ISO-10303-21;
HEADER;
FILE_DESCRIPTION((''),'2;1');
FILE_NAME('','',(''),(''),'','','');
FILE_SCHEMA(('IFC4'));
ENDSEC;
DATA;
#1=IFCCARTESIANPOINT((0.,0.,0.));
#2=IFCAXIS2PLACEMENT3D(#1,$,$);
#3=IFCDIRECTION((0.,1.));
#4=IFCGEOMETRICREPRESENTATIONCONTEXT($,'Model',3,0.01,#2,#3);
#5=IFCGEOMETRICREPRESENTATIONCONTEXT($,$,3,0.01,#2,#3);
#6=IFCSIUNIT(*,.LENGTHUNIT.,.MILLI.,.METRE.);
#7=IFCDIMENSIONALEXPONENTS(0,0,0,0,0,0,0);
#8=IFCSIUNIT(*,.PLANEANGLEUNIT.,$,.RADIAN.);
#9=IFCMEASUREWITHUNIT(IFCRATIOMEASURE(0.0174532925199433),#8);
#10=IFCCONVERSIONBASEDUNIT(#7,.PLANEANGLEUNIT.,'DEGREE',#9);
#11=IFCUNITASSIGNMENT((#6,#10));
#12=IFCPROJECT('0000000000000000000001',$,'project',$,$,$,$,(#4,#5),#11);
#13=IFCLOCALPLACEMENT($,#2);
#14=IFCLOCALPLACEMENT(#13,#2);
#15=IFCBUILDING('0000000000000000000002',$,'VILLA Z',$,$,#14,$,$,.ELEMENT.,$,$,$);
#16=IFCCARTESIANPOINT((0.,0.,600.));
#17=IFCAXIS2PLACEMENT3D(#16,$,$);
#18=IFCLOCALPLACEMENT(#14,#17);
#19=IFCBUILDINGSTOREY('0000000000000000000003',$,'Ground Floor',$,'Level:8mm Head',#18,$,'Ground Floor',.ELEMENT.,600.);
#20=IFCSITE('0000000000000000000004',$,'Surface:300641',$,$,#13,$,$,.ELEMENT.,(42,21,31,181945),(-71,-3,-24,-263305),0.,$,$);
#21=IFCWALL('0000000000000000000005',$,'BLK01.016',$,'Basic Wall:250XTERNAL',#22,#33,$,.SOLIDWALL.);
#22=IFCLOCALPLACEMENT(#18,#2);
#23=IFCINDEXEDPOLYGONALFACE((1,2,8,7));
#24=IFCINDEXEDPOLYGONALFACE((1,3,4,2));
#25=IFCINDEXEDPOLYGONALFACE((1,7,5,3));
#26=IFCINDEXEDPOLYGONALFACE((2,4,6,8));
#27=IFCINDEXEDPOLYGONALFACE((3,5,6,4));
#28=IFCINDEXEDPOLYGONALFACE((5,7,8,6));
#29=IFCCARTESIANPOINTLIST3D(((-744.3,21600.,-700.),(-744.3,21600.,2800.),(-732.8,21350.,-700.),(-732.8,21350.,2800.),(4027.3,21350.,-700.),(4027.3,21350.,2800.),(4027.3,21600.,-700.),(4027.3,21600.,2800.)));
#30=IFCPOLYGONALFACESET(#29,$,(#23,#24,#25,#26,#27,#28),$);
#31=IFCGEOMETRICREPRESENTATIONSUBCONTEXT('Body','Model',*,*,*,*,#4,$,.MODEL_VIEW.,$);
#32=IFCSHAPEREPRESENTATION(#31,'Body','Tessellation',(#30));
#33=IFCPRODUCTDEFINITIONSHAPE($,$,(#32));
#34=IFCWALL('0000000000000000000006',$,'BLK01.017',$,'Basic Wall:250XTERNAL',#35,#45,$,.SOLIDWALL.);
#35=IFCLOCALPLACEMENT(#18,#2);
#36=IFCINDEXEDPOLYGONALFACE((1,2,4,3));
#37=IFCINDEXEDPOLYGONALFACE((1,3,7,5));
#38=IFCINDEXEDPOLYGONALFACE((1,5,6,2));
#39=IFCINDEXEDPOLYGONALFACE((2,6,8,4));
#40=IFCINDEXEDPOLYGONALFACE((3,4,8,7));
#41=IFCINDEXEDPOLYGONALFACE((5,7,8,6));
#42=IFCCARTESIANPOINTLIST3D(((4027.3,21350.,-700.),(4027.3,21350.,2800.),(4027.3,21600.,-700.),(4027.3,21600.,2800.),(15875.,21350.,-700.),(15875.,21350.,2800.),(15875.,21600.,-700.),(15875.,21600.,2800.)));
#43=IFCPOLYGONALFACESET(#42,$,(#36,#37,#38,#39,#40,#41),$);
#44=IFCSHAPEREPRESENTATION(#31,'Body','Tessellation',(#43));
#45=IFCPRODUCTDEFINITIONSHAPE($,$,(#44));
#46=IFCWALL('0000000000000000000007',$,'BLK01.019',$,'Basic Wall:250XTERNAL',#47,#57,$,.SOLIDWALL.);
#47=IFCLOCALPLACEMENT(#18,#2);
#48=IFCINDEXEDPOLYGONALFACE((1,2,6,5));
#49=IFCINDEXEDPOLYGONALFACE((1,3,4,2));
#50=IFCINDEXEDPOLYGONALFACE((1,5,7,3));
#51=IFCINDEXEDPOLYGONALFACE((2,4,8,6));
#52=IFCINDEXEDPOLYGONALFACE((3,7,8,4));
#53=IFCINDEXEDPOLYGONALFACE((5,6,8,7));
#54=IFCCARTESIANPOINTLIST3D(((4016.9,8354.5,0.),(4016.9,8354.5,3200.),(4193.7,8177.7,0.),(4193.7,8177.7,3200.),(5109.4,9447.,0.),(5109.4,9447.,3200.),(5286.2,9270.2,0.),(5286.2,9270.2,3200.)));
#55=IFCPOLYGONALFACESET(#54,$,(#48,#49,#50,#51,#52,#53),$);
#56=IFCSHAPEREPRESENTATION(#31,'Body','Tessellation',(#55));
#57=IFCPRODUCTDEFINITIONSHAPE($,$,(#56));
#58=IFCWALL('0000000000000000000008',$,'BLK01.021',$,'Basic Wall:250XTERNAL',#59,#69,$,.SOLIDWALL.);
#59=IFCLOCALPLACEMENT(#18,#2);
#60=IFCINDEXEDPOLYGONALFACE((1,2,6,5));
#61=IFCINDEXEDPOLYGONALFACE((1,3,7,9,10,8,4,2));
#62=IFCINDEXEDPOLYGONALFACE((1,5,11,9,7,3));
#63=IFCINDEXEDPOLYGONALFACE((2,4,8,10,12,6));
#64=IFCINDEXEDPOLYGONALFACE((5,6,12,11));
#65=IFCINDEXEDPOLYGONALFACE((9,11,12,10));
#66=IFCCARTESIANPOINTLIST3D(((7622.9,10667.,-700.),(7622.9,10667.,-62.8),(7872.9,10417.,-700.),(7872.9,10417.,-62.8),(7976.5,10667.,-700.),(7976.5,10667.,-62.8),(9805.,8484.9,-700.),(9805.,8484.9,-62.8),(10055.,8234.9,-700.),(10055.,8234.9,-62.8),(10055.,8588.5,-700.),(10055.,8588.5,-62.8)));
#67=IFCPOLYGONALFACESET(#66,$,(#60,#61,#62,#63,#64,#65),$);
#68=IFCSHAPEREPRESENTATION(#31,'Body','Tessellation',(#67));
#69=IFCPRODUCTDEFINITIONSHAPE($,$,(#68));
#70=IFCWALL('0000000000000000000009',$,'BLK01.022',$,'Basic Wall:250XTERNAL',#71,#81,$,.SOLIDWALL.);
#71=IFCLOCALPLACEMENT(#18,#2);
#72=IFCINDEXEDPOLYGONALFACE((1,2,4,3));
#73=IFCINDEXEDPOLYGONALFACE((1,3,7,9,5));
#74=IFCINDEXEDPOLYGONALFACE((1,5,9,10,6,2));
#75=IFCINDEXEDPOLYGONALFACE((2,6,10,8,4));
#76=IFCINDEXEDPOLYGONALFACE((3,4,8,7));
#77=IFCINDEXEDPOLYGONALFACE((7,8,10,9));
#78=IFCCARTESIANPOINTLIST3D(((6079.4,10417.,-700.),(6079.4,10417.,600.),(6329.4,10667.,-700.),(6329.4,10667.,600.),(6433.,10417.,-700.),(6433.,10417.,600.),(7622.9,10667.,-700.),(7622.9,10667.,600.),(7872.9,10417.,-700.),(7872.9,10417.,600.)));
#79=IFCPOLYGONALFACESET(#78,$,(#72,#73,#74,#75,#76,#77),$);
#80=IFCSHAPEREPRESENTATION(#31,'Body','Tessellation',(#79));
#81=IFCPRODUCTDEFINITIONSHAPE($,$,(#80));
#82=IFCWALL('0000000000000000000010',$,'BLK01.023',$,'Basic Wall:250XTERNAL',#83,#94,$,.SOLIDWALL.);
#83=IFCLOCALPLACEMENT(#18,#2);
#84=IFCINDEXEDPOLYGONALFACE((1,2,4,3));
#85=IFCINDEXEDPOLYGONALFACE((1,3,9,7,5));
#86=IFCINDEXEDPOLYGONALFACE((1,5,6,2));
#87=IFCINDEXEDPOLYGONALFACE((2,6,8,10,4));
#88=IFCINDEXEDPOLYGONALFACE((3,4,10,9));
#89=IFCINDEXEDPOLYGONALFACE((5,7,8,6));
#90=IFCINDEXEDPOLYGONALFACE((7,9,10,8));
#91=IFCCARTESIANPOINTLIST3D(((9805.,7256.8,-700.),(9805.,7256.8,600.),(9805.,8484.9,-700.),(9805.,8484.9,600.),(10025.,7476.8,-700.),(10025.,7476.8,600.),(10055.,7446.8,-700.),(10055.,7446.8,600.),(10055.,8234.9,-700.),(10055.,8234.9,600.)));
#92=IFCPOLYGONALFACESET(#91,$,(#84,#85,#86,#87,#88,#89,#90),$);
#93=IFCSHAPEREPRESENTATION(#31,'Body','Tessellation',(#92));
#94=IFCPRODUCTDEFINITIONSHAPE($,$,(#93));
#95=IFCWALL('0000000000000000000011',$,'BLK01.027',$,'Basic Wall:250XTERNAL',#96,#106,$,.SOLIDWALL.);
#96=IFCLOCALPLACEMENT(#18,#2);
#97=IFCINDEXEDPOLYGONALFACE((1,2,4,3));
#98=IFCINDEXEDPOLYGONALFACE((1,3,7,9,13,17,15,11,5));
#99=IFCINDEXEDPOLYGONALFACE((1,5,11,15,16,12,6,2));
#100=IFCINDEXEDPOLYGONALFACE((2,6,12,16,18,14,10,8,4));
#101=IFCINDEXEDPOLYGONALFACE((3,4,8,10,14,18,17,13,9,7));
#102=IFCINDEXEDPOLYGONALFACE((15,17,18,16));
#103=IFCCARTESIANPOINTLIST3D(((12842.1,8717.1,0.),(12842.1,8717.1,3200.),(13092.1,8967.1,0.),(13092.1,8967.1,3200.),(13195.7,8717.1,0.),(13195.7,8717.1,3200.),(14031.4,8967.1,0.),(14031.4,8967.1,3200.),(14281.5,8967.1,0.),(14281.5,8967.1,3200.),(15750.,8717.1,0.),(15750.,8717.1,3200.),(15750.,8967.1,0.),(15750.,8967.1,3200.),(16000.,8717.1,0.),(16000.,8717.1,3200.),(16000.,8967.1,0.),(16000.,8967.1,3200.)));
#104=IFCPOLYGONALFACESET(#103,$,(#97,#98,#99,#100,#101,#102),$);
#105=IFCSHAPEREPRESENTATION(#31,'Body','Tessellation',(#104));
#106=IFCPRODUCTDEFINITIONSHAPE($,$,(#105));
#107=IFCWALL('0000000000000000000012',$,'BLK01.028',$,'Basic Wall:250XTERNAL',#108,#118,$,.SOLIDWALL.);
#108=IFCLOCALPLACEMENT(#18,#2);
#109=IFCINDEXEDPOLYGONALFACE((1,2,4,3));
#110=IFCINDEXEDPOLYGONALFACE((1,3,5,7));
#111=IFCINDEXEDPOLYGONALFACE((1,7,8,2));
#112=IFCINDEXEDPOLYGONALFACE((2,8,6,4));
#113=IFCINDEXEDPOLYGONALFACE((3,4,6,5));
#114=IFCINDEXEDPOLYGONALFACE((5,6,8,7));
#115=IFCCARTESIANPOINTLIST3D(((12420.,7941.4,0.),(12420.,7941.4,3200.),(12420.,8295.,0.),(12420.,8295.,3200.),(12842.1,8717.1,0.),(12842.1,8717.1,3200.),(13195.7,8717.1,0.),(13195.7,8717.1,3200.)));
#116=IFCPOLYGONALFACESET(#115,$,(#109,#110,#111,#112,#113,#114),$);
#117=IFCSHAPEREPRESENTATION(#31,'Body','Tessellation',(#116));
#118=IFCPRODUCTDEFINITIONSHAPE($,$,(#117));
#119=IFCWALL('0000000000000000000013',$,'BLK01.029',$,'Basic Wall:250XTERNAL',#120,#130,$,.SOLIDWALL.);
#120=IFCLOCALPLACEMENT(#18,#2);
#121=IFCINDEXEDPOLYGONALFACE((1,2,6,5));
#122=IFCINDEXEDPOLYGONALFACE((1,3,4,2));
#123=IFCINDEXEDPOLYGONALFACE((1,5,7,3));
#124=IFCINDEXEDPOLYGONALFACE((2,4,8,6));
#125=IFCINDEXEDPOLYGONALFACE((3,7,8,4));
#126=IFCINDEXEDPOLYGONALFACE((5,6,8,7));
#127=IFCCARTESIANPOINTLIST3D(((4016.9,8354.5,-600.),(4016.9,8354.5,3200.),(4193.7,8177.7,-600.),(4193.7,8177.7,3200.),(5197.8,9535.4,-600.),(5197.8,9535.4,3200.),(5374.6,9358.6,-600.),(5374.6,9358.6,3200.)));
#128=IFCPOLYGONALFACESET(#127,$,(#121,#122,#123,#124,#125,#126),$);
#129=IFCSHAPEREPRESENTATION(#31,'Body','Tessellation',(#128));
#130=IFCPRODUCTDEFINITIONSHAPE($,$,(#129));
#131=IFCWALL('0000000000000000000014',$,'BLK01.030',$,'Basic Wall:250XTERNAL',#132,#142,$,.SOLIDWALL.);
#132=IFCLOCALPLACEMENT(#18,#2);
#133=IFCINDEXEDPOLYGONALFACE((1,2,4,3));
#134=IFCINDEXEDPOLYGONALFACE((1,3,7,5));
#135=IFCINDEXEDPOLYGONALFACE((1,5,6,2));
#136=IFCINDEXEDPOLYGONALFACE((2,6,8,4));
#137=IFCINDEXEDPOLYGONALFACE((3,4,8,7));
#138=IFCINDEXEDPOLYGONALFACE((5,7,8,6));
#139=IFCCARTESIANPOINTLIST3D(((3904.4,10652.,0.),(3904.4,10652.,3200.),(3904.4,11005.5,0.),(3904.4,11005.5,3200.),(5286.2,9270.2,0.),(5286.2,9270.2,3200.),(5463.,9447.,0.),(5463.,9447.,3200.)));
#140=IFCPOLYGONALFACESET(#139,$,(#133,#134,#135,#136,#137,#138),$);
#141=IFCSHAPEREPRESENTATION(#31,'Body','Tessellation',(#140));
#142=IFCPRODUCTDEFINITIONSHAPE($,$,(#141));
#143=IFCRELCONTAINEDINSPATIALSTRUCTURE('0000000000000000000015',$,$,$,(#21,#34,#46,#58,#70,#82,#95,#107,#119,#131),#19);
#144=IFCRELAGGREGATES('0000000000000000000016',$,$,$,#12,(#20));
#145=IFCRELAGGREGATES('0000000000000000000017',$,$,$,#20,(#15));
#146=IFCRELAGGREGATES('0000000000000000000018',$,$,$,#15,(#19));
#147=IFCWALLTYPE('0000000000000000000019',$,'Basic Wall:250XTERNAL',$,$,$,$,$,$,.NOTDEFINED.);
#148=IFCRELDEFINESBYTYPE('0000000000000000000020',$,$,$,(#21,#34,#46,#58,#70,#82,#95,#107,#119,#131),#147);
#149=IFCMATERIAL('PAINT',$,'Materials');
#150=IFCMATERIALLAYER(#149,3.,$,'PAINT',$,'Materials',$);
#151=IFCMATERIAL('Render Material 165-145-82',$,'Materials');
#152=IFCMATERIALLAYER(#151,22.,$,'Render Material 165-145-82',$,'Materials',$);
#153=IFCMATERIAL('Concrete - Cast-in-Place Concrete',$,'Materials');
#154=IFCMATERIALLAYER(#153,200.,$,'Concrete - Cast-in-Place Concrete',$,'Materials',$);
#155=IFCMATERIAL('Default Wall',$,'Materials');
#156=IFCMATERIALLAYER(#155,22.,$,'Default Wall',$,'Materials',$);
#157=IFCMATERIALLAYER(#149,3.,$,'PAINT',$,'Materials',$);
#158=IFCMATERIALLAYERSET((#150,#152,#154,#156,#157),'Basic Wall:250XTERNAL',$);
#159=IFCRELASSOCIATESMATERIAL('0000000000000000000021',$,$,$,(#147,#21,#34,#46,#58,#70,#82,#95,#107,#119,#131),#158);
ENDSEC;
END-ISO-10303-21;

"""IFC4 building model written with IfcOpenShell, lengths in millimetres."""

from ifc_helpers import new_model, entity, si_unit, converted_unit, direction, frame, frame_2d, origin, place, context, subcontext, project, spatial, polyline, rectangle, outline, extrude, clip, halfspace, material, layer, layer_set, layer_usage, type_object, element, save


model = new_model("IFC4")

# Units and contexts
model_context = context("Model", 3, precision=0.01, world=origin(), true_north=direction((0.0, 1.0)))
context_of_model = context(None, 3, precision=0.01, world=origin(), true_north=direction((0.0, 1.0)))
body_context = subcontext(model_context, "Body", "Model", "MODEL_VIEW")
ifc_project = project(units=[si_unit("LENGTHUNIT", "METRE", prefix="MILLI"), converted_unit("PLANEANGLEUNIT", "DEGREE", entity("IfcRatioMeasure", 0.0174532925199433), si_unit("PLANEANGLEUNIT", "RADIAN"), dimensions=[0, 0, 0, 0, 0, 0, 0])], contexts=[model_context, context_of_model])

# Site, building, storey
site_placement = place(None, origin())
site = spatial("IfcSite", under=ifc_project, at=site_placement, Name="Surface:300641", CompositionType="ELEMENT", RefLatitude=(42, 21, 31, 181945), RefLongitude=(-71, -3, -24, -263305), RefElevation=0.0)
building_placement = place(site_placement, origin())
building = spatial("IfcBuilding", under=site, at=building_placement, Name="VILLA Z", CompositionType="ELEMENT")
storey_placement = place(building_placement, frame((0.0, 0.0, 600.0)))
storey = spatial("IfcBuildingStorey", under=building, at=storey_placement, Name="Ground Floor", ObjectType="Level:8mm Head", LongName="Ground Floor", CompositionType="ELEMENT", Elevation=600.0)

# Walls
ifc_material_1 = material(Name="PAINT", Category="Materials")
ifc_layer_1 = layer(ifc_material_1, 3.0, Name="PAINT", Category="Materials")
ifc_material_2 = material(Name="Render Material 165-145-82", Category="Materials")
ifc_layer_2 = layer(ifc_material_2, 22.0, Name="Render Material 165-145-82", Category="Materials")
ifc_material_3 = material(Name="Concrete - Cast-in-Place Concrete", Category="Materials")
ifc_layer_3 = layer(ifc_material_3, 200.0, Name="Concrete - Cast-in-Place Concrete", Category="Materials")
ifc_material_4 = material(Name="Default Wall", Category="Materials")
ifc_layer_4 = layer(ifc_material_4, 22.0, Name="Default Wall", Category="Materials")
ifc_layer_5 = layer(ifc_material_1, 3.0, Name="PAINT", Category="Materials")
ifc_layer_set_1 = layer_set([ifc_layer_1, ifc_layer_2, ifc_layer_3, ifc_layer_4, ifc_layer_5], Name="Basic Wall:250XTERNAL")
ifc_layer_usage_1 = layer_usage(ifc_layer_set_1, "AXIS2", "NEGATIVE", 125.0)
wall_type_1 = type_object("IfcWallType", Name="Basic Wall:250XTERNAL", PredefinedType="NOTDEFINED", material=ifc_layer_set_1)
wall_1_placement = place(storey_placement, frame((-744.3, 21475.0, -700.0)))
element("IfcWall", 1, at=wall_1_placement, inside=storey, type_object=wall_type_1, material=ifc_layer_usage_1, Name="BLK01.016", ObjectType="Basic Wall:250XTERNAL", PredefinedType="SOLIDWALL", context=body_context, shape_type="SweptSolid", body=[
    extrude(outline(polyline([(4771.6, -125.0), (4771.6, 125.0), (0.0, 125.0), (11.5, -125.0), (4771.6, -125.0)])), origin(), (0.0, 0.0, 1.0), 3500.0),
])
ifc_layer_usage_2 = layer_usage(ifc_layer_set_1, "AXIS2", "NEGATIVE", 125.0)
wall_2_placement = place(storey_placement, frame((4027.3, 21475.0, -700.0)))
element("IfcWall", 2, at=wall_2_placement, inside=storey, type_object=wall_type_1, material=ifc_layer_usage_2, Name="BLK01.017", ObjectType="Basic Wall:250XTERNAL", PredefinedType="SOLIDWALL", context=body_context, shape_type="SweptSolid", body=[
    extrude(rectangle(XDim=11847.7, YDim=250.0, at=frame_2d((5923.8, 0.0), x_axis=(-1.0, 0.0))), origin(), (0.0, 0.0, 1.0), 3500.0),
])
ifc_layer_usage_3 = layer_usage(ifc_layer_set_1, "AXIS2", "NEGATIVE", 125.0)
wall_3_placement = place(storey_placement, frame((4105.3, 8266.1, 0.0), z_axis=(0.0, 0.0, 1.0), x_axis=(0.707107, 0.707107, 0.0)))
element("IfcWall", 3, at=wall_3_placement, inside=storey, type_object=wall_type_1, material=ifc_layer_usage_3, Name="BLK01.019", ObjectType="Basic Wall:250XTERNAL", PredefinedType="SOLIDWALL", context=body_context, shape_type="Clipping", body=[
    clip(extrude(rectangle(XDim=1545.0, YDim=250.0, at=frame_2d((772.5, 0.0), x_axis=(-1.0, 0.0))), origin(), (0.0, 0.0, 1.0), 3200.0), halfspace(origin(), True)),
])
ifc_layer_usage_4 = layer_usage(ifc_layer_set_1, "AXIS2", "NEGATIVE", 125.0)
wall_4_placement = place(storey_placement, frame((10143.4, 8323.3, -700.0), z_axis=(0.0, 0.0, 1.0), x_axis=(-0.707107, 0.707107, 0.0)))
element("IfcWall", 4, at=wall_4_placement, inside=storey, type_object=wall_type_1, material=ifc_layer_usage_4, Name="BLK01.021", ObjectType="Basic Wall:250XTERNAL", PredefinedType="SOLIDWALL", context=body_context, shape_type="SweptSolid", body=[
    extrude(outline(polyline([(3189.5, -125.0), (3439.5, 125.0), (3086.0, 125.0), (353.6, 125.0), (0.0, 125.0), (250.0, -125.0), (3189.5, -125.0)])), origin(), (0.0, 0.0, 1.0), 637.2),
])
ifc_layer_usage_5 = layer_usage(ifc_layer_set_1, "AXIS2", "POSITIVE", -125.0)
wall_5_placement = place(storey_placement, frame((7872.9, 10542.0, -700.0), z_axis=(0.0, 0.0, 1.0), x_axis=(-1.0, 0.0, 0.0)))
element("IfcWall", 5, at=wall_5_placement, inside=storey, type_object=wall_type_1, material=ifc_layer_usage_5, Name="BLK01.022", ObjectType="Basic Wall:250XTERNAL", PredefinedType="SOLIDWALL", context=body_context, shape_type="SweptSolid", body=[
    extrude(outline(polyline([(1543.5, -125.0), (1793.5, 125.0), (1439.9, 125.0), (0.0, 125.0), (250.0, -125.0), (1543.5, -125.0)])), origin(), (0.0, 0.0, 1.0), 1300.0),
])
ifc_layer_usage_6 = layer_usage(ifc_layer_set_1, "AXIS2", "NEGATIVE", 125.0)
wall_6_placement = place(storey_placement, frame((9930.0, 8484.9, -700.0), z_axis=(0.0, 0.0, 1.0), x_axis=(0.0, -1.0, 0.0)))
element("IfcWall", 6, at=wall_6_placement, inside=storey, type_object=wall_type_1, material=ifc_layer_usage_6, Name="BLK01.023", ObjectType="Basic Wall:250XTERNAL", PredefinedType="SOLIDWALL", context=body_context, shape_type="SweptSolid", body=[
    extrude(outline(polyline([(1228.2, -125.0), (1008.2, 95.0), (1038.2, 125.0), (250.0, 125.0), (0.0, -125.0), (1228.2, -125.0)])), origin(), (0.0, 0.0, 1.0), 1300.0),
])
ifc_layer_usage_7 = layer_usage(ifc_layer_set_1, "AXIS2", "NEGATIVE", 125.0)
wall_7_placement = place(storey_placement, frame((16000.0, 8842.1, 0.0), z_axis=(0.0, 0.0, 1.0), x_axis=(-1.0, 0.0, 0.0)))
element("IfcWall", 7, at=wall_7_placement, inside=storey, type_object=wall_type_1, material=ifc_layer_usage_7, Name="BLK01.027", ObjectType="Basic Wall:250XTERNAL", PredefinedType="SOLIDWALL", context=body_context, shape_type="SweptSolid", body=[
    extrude(outline(polyline([(2907.9, -125.0), (3157.9, 125.0), (2804.3, 125.0), (250.0, 125.0), (0.0, 125.0), (0.0, -125.0), (250.0, -125.0), (1718.5, -125.0), (1968.6, -125.0), (2907.9, -125.0)])), origin(), (0.0, 0.0, 1.0), 3200.0),
])
ifc_layer_usage_8 = layer_usage(ifc_layer_set_1, "AXIS2", "NEGATIVE", 125.0)
wall_8_placement = place(storey_placement, frame((12331.6, 8029.8, 0.0), z_axis=(0.0, 0.0, 1.0), x_axis=(0.707107, 0.707107, 0.0)))
element("IfcWall", 8, at=wall_8_placement, inside=storey, type_object=wall_type_1, material=ifc_layer_usage_8, Name="BLK01.028", ObjectType="Basic Wall:250XTERNAL", PredefinedType="SOLIDWALL", context=body_context, shape_type="Clipping", body=[
    clip(extrude(outline(polyline([(1097.0, -125.0), (847.0, 125.0), (250.0, 125.0), (0.0, -125.0), (1097.0, -125.0)])), origin(), (0.0, 0.0, 1.0), 3200.0), halfspace(origin(), True)),
])
ifc_layer_usage_9 = layer_usage(ifc_layer_set_1, "AXIS2", "NEGATIVE", 125.0)
wall_9_placement = place(storey_placement, frame((4105.3, 8266.1, -600.0), z_axis=(0.0, 0.0, 1.0), x_axis=(0.707107, 0.707107, 0.0)))
element("IfcWall", 9, at=wall_9_placement, inside=storey, type_object=wall_type_1, material=ifc_layer_usage_9, Name="BLK01.029", ObjectType="Basic Wall:250XTERNAL", PredefinedType="SOLIDWALL", context=body_context, shape_type="Clipping", body=[
    clip(extrude(rectangle(XDim=1670.0, YDim=250.0, at=frame_2d((835.0, 0.0), x_axis=(-1.0, 0.0))), origin(), (0.0, 0.0, 1.0), 3800.0), halfspace(frame((0.0, 0.0, -600.0)), True)),
])
ifc_layer_usage_10 = layer_usage(ifc_layer_set_1, "AXIS2", "NEGATIVE", 125.0)
wall_10_placement = place(storey_placement, frame((5374.6, 9358.6, 0.0), z_axis=(0.0, 0.0, 1.0), x_axis=(-0.707107, 0.707107, 0.0)))
element("IfcWall", 10, at=wall_10_placement, inside=storey, type_object=wall_type_1, material=ifc_layer_usage_10, Name="BLK01.030", ObjectType="Basic Wall:250XTERNAL", PredefinedType="SOLIDWALL", context=body_context, shape_type="Clipping", body=[
    clip(extrude(outline(polyline([(2204.1, -125.0), (1954.1, 125.0), (250.0, 125.0), (0.0, 125.0), (0.0, 0.0), (0.0, -125.0), (250.0, -125.0), (1850.5, -125.0), (2204.1, -125.0)])), origin(), (0.0, 0.0, 1.0), 3200.0), halfspace(origin(), True)),
])

save(model, "model.ifc")
